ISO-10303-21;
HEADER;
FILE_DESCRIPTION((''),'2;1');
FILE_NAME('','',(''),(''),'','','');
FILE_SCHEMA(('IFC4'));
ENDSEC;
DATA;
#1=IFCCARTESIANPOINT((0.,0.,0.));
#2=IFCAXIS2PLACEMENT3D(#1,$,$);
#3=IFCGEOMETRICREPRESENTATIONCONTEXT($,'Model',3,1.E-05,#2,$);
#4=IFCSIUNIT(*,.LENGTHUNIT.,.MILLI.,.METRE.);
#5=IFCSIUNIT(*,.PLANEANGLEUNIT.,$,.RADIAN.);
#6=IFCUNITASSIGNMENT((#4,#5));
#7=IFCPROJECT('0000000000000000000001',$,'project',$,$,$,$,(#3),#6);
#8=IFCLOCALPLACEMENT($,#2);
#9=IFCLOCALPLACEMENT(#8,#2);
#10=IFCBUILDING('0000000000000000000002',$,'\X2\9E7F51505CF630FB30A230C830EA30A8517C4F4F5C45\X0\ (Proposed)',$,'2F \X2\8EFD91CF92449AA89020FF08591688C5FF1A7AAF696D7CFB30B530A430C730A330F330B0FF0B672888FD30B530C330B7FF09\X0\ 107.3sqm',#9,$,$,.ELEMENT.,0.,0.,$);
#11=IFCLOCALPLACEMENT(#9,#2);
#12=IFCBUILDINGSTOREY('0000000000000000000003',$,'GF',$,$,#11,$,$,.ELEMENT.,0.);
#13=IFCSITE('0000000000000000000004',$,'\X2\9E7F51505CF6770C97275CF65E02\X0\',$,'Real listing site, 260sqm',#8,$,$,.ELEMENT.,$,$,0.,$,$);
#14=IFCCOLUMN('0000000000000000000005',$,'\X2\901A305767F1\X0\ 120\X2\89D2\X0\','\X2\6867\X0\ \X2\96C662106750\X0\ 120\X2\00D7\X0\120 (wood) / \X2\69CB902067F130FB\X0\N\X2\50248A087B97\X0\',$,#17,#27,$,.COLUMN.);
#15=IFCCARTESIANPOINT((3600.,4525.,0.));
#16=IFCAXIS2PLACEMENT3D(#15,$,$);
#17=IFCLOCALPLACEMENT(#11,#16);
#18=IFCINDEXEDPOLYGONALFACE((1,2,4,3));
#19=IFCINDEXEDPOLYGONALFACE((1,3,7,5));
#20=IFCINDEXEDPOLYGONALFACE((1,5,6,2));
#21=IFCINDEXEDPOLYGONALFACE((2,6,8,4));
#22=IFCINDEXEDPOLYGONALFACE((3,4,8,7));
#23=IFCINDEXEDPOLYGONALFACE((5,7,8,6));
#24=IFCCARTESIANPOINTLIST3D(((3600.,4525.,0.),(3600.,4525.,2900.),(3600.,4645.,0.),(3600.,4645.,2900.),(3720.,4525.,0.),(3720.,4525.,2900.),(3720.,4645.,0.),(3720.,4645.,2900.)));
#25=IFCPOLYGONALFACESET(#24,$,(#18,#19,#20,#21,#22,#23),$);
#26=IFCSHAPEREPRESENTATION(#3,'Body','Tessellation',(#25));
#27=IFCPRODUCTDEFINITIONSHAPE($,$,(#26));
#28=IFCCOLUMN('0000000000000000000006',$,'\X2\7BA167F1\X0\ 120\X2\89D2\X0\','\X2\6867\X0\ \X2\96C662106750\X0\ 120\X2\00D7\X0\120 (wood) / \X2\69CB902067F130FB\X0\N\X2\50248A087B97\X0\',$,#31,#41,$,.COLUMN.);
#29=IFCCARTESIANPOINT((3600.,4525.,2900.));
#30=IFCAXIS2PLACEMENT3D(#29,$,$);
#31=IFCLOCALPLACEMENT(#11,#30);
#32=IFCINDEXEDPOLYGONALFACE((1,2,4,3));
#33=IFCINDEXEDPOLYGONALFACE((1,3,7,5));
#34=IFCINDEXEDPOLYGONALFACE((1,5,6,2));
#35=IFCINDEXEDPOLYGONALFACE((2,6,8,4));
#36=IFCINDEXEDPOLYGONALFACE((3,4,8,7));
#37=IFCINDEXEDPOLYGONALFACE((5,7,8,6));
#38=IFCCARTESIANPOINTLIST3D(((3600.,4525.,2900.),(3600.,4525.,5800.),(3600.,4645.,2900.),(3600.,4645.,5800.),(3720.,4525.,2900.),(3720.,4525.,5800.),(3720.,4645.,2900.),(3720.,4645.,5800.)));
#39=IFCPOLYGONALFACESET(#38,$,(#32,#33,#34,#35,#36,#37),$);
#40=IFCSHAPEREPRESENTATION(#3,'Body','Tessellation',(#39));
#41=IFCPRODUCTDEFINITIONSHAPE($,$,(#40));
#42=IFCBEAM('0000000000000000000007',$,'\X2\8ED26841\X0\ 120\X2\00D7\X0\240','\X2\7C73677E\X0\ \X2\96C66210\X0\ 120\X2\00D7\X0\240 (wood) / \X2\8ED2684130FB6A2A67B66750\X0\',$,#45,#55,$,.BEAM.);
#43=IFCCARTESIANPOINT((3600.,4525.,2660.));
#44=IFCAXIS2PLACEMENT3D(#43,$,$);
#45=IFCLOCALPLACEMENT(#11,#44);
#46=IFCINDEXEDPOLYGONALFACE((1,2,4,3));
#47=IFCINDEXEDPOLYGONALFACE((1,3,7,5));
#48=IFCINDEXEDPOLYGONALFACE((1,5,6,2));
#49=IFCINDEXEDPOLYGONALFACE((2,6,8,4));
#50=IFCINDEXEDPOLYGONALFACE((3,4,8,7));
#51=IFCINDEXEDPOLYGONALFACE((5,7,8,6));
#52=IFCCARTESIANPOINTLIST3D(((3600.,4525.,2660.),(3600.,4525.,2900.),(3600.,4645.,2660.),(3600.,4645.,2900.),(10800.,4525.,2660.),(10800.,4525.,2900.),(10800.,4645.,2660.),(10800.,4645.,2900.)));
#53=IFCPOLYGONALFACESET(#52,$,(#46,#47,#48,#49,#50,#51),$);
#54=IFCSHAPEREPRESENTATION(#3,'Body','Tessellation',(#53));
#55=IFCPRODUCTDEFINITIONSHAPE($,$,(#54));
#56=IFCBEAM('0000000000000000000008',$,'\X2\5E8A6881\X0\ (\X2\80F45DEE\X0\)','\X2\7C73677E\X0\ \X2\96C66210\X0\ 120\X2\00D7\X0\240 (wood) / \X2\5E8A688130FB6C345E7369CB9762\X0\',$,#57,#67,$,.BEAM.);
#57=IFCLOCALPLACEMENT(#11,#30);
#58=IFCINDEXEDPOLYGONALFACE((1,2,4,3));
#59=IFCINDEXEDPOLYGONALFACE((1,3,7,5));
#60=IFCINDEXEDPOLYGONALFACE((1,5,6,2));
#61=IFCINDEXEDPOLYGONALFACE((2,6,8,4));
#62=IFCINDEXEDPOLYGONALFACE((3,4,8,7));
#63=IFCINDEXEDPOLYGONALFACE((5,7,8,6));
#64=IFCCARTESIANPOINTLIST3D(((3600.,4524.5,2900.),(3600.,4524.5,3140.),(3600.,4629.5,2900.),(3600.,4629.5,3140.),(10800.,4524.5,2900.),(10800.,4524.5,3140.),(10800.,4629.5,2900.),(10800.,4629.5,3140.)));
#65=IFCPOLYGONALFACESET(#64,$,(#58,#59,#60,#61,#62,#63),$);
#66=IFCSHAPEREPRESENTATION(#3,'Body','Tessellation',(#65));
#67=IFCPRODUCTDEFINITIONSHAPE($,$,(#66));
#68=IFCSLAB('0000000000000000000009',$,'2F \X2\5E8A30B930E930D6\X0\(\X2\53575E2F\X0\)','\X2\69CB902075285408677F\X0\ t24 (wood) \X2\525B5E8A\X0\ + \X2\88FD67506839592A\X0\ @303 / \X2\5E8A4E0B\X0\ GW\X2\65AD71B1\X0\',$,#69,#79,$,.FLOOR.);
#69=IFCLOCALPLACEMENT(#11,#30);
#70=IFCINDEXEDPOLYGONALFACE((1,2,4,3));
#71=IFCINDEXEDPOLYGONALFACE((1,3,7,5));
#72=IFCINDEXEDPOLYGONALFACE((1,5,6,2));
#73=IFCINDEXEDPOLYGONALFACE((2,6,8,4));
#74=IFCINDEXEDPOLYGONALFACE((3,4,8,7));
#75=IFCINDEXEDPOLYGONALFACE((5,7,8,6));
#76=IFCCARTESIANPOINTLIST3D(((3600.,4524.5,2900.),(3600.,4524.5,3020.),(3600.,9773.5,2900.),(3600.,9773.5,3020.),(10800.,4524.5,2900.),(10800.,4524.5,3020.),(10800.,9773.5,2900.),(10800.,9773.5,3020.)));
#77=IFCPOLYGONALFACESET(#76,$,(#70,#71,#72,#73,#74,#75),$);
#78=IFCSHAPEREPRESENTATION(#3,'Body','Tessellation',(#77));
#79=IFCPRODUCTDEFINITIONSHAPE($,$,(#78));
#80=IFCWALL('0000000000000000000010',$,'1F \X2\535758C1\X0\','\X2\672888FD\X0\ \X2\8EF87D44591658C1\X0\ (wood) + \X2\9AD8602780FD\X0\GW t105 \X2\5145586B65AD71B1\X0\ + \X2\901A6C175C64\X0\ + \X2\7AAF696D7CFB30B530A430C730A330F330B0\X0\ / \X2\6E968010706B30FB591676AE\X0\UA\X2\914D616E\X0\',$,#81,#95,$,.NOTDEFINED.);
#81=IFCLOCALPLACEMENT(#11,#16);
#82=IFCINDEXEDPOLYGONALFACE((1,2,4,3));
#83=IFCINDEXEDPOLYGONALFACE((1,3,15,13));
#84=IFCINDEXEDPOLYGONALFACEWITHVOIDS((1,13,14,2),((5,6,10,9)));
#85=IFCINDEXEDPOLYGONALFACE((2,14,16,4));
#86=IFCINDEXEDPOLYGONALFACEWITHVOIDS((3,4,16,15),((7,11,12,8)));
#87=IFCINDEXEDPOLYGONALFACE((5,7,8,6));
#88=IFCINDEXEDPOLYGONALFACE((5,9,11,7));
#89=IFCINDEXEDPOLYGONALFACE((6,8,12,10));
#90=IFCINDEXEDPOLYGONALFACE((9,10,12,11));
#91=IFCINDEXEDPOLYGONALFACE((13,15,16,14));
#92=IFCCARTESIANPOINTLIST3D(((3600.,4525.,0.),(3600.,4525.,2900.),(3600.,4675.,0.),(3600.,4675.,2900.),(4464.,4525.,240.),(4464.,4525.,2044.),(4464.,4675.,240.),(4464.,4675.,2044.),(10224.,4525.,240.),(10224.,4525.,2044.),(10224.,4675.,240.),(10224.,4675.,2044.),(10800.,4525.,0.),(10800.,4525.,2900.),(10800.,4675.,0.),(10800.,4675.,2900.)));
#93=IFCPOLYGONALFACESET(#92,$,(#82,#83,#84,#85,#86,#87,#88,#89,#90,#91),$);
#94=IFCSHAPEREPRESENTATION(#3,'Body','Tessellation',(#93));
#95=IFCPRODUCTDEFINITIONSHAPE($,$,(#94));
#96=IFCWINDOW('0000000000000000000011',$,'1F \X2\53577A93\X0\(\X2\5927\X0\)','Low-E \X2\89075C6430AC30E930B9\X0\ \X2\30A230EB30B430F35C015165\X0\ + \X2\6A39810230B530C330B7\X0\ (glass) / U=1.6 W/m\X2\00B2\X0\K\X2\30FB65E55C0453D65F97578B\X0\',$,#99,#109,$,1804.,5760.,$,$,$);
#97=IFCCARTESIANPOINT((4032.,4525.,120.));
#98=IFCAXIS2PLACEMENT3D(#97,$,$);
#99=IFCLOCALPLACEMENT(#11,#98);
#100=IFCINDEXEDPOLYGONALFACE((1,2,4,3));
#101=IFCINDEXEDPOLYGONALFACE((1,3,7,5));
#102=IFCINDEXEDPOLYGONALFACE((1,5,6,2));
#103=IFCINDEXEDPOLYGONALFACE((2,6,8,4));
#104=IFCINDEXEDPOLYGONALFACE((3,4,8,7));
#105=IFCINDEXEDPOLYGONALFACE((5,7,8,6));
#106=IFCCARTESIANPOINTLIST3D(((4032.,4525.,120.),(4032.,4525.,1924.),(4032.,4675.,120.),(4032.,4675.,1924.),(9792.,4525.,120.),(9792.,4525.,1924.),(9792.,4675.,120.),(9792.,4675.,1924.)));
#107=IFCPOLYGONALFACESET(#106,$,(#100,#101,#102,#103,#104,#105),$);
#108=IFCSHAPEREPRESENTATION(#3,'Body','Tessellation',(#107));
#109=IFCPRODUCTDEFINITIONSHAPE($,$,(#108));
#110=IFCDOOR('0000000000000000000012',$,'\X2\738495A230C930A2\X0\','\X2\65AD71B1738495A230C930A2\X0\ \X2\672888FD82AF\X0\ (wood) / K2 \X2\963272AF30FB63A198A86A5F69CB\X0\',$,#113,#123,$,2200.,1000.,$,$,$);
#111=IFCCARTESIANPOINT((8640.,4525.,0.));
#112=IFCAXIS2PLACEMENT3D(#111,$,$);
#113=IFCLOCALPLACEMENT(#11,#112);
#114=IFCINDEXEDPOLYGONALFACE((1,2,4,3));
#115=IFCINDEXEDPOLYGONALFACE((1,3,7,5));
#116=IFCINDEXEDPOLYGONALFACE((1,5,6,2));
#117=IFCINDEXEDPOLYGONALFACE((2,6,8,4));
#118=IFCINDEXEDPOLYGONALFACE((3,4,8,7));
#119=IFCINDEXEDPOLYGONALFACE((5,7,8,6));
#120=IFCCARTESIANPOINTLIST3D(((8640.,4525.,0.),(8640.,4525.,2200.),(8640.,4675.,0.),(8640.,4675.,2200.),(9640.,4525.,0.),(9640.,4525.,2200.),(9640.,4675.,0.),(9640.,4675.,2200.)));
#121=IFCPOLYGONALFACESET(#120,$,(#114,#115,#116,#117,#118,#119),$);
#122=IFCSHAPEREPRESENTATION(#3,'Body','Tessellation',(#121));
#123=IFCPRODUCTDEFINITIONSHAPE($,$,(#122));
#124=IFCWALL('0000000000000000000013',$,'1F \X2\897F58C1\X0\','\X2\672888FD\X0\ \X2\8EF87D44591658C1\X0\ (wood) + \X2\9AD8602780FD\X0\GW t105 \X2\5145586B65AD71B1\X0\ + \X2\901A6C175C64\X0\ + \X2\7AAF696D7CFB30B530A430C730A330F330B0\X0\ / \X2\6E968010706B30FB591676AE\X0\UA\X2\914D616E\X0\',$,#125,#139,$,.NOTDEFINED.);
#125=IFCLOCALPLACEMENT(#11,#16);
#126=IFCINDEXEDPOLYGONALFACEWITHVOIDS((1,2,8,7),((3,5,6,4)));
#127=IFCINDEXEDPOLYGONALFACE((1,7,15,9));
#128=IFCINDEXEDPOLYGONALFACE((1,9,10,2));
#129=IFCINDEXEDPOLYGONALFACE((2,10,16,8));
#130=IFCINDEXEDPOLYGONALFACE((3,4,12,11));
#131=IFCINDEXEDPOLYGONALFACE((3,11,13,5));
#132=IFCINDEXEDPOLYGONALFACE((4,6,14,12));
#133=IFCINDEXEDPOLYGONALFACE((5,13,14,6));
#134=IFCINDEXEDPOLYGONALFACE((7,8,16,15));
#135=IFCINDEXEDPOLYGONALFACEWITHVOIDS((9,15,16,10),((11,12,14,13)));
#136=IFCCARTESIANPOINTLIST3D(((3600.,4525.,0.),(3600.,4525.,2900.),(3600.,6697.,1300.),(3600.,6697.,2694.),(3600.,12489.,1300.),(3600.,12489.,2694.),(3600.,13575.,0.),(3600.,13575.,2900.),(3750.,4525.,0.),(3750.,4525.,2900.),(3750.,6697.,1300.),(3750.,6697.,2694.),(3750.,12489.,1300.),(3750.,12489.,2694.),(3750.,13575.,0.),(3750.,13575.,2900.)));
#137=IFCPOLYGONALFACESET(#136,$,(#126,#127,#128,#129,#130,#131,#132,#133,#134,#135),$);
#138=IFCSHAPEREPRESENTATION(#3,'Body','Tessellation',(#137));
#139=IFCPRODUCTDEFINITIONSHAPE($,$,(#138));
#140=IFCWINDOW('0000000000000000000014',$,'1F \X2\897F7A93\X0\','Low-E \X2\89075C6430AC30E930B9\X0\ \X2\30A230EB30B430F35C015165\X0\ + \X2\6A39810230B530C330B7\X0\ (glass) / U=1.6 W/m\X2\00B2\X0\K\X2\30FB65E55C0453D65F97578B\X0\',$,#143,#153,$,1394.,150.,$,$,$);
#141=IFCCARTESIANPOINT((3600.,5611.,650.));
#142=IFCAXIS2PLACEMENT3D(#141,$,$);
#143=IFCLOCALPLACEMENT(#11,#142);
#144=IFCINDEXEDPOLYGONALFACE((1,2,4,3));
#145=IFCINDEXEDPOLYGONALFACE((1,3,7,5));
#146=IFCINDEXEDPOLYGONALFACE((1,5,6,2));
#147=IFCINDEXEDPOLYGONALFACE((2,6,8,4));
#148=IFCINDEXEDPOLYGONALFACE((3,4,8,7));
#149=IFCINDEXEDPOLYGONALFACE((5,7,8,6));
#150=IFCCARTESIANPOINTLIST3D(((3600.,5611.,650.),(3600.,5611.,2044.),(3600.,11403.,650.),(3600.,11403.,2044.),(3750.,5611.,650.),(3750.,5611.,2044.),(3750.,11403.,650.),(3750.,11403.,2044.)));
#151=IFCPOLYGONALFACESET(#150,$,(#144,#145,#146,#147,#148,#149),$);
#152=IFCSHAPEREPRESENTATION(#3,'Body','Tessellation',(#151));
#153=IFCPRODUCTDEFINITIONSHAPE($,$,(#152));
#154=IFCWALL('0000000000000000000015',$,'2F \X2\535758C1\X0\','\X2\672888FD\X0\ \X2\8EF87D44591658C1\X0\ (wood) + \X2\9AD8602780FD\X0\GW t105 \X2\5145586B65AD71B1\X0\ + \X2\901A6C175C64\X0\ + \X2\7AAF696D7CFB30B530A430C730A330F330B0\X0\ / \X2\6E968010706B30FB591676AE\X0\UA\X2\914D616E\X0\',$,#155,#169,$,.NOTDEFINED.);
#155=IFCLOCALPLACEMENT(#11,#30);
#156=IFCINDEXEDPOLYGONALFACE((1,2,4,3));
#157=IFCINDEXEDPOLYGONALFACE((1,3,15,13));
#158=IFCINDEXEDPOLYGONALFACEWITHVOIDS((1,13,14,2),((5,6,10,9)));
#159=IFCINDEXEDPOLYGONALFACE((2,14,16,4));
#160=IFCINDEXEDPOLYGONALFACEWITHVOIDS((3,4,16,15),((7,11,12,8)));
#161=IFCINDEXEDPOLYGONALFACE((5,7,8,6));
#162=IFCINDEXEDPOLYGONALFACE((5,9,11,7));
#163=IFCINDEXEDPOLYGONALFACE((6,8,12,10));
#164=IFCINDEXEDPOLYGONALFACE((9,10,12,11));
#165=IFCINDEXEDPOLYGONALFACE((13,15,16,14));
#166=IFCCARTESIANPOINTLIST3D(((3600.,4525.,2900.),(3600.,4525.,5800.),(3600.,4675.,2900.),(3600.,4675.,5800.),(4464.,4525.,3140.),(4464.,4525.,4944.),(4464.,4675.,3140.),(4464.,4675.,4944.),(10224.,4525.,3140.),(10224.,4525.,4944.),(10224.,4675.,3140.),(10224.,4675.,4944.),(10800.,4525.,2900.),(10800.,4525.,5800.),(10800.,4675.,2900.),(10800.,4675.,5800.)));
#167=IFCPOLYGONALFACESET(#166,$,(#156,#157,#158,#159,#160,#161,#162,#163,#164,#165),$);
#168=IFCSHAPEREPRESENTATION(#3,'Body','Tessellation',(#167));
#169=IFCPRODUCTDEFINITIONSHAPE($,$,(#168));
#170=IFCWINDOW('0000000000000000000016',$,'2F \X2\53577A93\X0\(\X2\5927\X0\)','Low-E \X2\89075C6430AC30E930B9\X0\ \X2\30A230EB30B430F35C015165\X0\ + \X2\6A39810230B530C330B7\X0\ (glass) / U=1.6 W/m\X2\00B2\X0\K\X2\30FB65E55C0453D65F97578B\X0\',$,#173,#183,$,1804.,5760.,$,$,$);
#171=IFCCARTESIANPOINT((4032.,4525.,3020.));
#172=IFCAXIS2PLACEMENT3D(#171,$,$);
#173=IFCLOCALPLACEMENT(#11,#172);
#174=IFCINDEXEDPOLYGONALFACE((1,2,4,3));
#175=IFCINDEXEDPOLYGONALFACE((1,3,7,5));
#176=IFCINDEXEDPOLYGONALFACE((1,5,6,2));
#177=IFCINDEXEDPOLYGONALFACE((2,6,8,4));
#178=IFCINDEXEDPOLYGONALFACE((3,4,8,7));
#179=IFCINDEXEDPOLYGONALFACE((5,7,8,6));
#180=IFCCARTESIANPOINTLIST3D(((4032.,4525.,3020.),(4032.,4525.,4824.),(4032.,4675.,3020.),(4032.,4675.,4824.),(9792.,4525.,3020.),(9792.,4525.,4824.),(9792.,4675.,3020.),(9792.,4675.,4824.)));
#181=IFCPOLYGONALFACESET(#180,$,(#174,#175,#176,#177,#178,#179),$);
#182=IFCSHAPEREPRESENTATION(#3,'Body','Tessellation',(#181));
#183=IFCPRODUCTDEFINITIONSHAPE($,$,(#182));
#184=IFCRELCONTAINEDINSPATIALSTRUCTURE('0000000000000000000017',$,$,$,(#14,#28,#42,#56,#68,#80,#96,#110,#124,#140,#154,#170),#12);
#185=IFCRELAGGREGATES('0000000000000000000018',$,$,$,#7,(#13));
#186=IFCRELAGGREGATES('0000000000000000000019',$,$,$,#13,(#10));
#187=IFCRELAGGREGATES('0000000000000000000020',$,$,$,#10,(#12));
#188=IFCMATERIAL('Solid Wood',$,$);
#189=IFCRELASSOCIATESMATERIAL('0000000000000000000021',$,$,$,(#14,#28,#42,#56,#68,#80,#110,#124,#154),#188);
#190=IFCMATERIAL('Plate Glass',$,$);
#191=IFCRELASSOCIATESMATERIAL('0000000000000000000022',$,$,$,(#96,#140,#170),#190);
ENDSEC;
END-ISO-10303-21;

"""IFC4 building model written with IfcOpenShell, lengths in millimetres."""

from ifc_helpers import new_model, si_unit, frame, frame_2d, origin, place, context, project, spatial, rectangle, extrude, material, element, fill, save


model = new_model("IFC4")

# Units and contexts
model_context = context("Model", 3, precision=1e-05, world=origin())
ifc_project = project(units=[si_unit("LENGTHUNIT", "METRE", prefix="MILLI"), si_unit("PLANEANGLEUNIT", "RADIAN")], contexts=[model_context])

# Site, building, storey
site_placement = place(None, origin())
site = spatial("IfcSite", under=ifc_project, at=site_placement, Name="鹿児島県霧島市", ObjectType="Real listing site, 260sqm", CompositionType="ELEMENT", RefElevation=0.0)
building_placement = place(site_placement, origin())
building = spatial("IfcBuilding", under=site, at=building_placement, Name="鹿児島・アトリエ兼住居 (Proposed)", ObjectType="2F 軽量鉄骨造（外装：窯業系サイディング＋木製サッシ） 107.3sqm", CompositionType="ELEMENT", ElevationOfRefHeight=0.0, ElevationOfTerrain=0.0)
storey_placement = place(building_placement, origin())
storey = spatial("IfcBuildingStorey", under=building, at=storey_placement, Name="GF", CompositionType="ELEMENT", Elevation=0.0)

# Columns
ifc_material_1 = material(Name="Solid Wood")
column_1_placement = place(storey_placement, frame((3600.0, 4525.0, 0.0)))
element("IfcColumn", 1, at=column_1_placement, inside=storey, material=ifc_material_1, Name="通し柱 120角", Description="桧 集成材 120×120 (wood) / 構造柱・N値計算", PredefinedType="COLUMN", context=model_context, shape_type="SweptSolid", body=[
    extrude(rectangle(XDim=120.0, YDim=120.0, at=frame_2d((60.0, 60.0))), frame((3600.0, 4525.0, 0.0)), (0.0, 0.0, 1.0), 2900.0),
])
column_2_placement = place(storey_placement, frame((3600.0, 4525.0, 2900.0)))
element("IfcColumn", 2, at=column_2_placement, inside=storey, material=ifc_material_1, Name="管柱 120角", Description="桧 集成材 120×120 (wood) / 構造柱・N値計算", PredefinedType="COLUMN", context=model_context, shape_type="SweptSolid", body=[
    extrude(rectangle(XDim=120.0, YDim=120.0, at=frame_2d((60.0, 60.0))), frame((3600.0, 4525.0, 2900.0)), (0.0, 0.0, 1.0), 2900.0),
])

# Beams
beam_1_placement = place(storey_placement, frame((3600.0, 4525.0, 2660.0)))
element("IfcBeam", 3, at=beam_1_placement, inside=storey, material=ifc_material_1, Name="軒桁 120×240", Description="米松 集成 120×240 (wood) / 軒桁・横架材", PredefinedType="BEAM", context=model_context, shape_type="SweptSolid", body=[
    extrude(rectangle(XDim=7200.0, YDim=120.0, at=frame_2d((3600.0, 60.0))), frame((3600.0, 4525.0, 2660.0)), (0.0, 0.0, 1.0), 240.0),
])
beam_2_placement = place(storey_placement, frame((3600.0, 4525.0, 2900.0)))
element("IfcBeam", 4, at=beam_2_placement, inside=storey, material=ifc_material_1, Name="床梁 (胴差)", Description="米松 集成 120×240 (wood) / 床梁・水平構面", PredefinedType="BEAM", context=model_context, shape_type="SweptSolid", body=[
    extrude(rectangle(XDim=7200.0, YDim=105.0, at=frame_2d((3600.0, 52.0))), frame((3600.0, 4525.0, 2900.0)), (0.0, 0.0, 1.0), 240.0),
])

# Slab
slab_1_placement = place(storey_placement, frame((3600.0, 4525.0, 2900.0)))
element("IfcSlab", 5, at=slab_1_placement, inside=storey, material=ifc_material_1, Name="2F 床スラブ(南帯)", Description="構造用合板 t24 (wood) 剛床 + 製材根太 @303 / 床下 GW断熱", PredefinedType="FLOOR", context=model_context, shape_type="SweptSolid", body=[
    extrude(rectangle(XDim=7200.0, YDim=5249.0, at=frame_2d((3600.0, 2624.0))), frame((3600.0, 4525.0, 2900.0)), (0.0, 0.0, 1.0), 120.0),
])

# Wall, openings, window, door
wall_1_placement = place(storey_placement, frame((3600.0, 4525.0, 0.0)))
wall_1 = element("IfcWall", 6, at=wall_1_placement, inside=storey, material=ifc_material_1, Name="1F 南壁", Description="木製 軸組外壁 (wood) + 高性能GW t105 充填断熱 + 通気層 + 窯業系サイディング / 準耐火・外皮UA配慮", PredefinedType="NOTDEFINED", context=model_context, shape_type="SweptSolid", body=[
    extrude(rectangle(XDim=7200.0, YDim=150.0, at=frame_2d((3600.0, 75.0))), frame((3600.0, 4525.0, 0.0)), (0.0, 0.0, 1.0), 2900.0),
])
opening_1_placement = place(storey_placement, frame((4032.0, 4525.0, 120.0)))
opening_1 = element("IfcOpeningElement", 7, at=opening_1_placement, cuts=wall_1, PredefinedType="NOTDEFINED", context=model_context, shape_type="SweptSolid", body=[
    extrude(rectangle(XDim=5760.0, YDim=150.0, at=frame_2d((2880.0, 75.0))), frame((4032.0, 4525.0, 120.0)), (0.0, 0.0, 1.0), 1804.0),
])
opening_2_placement = place(storey_placement, frame((8640.0, 4525.0, 0.0)))
opening_2 = element("IfcOpeningElement", 8, at=opening_2_placement, cuts=wall_1, PredefinedType="NOTDEFINED", context=model_context, shape_type="SweptSolid", body=[
    extrude(rectangle(XDim=1000.0, YDim=150.0, at=frame_2d((500.0, 75.0))), frame((8640.0, 4525.0, 0.0)), (0.0, 0.0, 1.0), 2200.0),
])
ifc_material_2 = material(Name="Plate Glass")
window_1_placement = place(storey_placement, frame((4032.0, 4525.0, 120.0)))
window_1 = element("IfcWindow", 9, at=window_1_placement, inside=storey, material=ifc_material_2, Name="1F 南窓(大)", Description="Low-E 複層ガラス アルゴン封入 + 樹脂サッシ (glass) / U=1.6 W/m²K・日射取得型", OverallHeight=1804.0, OverallWidth=5760.0, context=model_context, shape_type="SweptSolid", body=[
    extrude(rectangle(XDim=5760.0, YDim=150.0, at=frame_2d((2880.0, 75.0))), frame((4032.0, 4525.0, 120.0)), (0.0, 0.0, 1.0), 1804.0),
])
fill(opening_1, window_1)
door_placement = place(storey_placement, frame((8640.0, 4525.0, 0.0)))
door = element("IfcDoor", 10, at=door_placement, inside=storey, material=ifc_material_1, Name="玄関ドア", Description="断熱玄関ドア 木製芯 (wood) / K2 防犯・採風機構", OverallHeight=2200.0, OverallWidth=1000.0, context=model_context, shape_type="SweptSolid", body=[
    extrude(rectangle(XDim=1000.0, YDim=150.0, at=frame_2d((500.0, 75.0))), frame((8640.0, 4525.0, 0.0)), (0.0, 0.0, 1.0), 2200.0),
])
fill(opening_2, door)

# Walls, openings, windows
wall_2_placement = place(storey_placement, frame((3600.0, 4525.0, 0.0)))
wall_2 = element("IfcWall", 11, at=wall_2_placement, inside=storey, material=ifc_material_1, Name="1F 西壁", Description="木製 軸組外壁 (wood) + 高性能GW t105 充填断熱 + 通気層 + 窯業系サイディング / 準耐火・外皮UA配慮", PredefinedType="NOTDEFINED", context=model_context, shape_type="SweptSolid", body=[
    extrude(rectangle(XDim=150.0, YDim=9050.0, at=frame_2d((75.0, 4525.0))), frame((3600.0, 4525.0, 0.0)), (0.0, 0.0, 1.0), 2900.0),
])
opening_3_placement = place(storey_placement, frame((3600.0, 5611.0, 650.0)))
opening_3 = element("IfcOpeningElement", 12, at=opening_3_placement, cuts=wall_2, PredefinedType="NOTDEFINED", context=model_context, shape_type="SweptSolid", body=[
    extrude(rectangle(XDim=150.0, YDim=5792.0, at=frame_2d((75.0, 2896.0))), frame((3600.0, 5611.0, 650.0)), (0.0, 0.0, 1.0), 1394.0),
])
window_2_placement = place(storey_placement, frame((3600.0, 5611.0, 650.0)))
window_2 = element("IfcWindow", 13, at=window_2_placement, inside=storey, material=ifc_material_2, Name="1F 西窓", Description="Low-E 複層ガラス アルゴン封入 + 樹脂サッシ (glass) / U=1.6 W/m²K・日射取得型", OverallHeight=1394.0, OverallWidth=150.0, context=model_context, shape_type="SweptSolid", body=[
    extrude(rectangle(XDim=150.0, YDim=5792.0, at=frame_2d((75.0, 2896.0))), frame((3600.0, 5611.0, 650.0)), (0.0, 0.0, 1.0), 1394.0),
])
fill(opening_3, window_2)
wall_3_placement = place(storey_placement, frame((3600.0, 4525.0, 2900.0)))
wall_3 = element("IfcWall", 14, at=wall_3_placement, inside=storey, material=ifc_material_1, Name="2F 南壁", Description="木製 軸組外壁 (wood) + 高性能GW t105 充填断熱 + 通気層 + 窯業系サイディング / 準耐火・外皮UA配慮", PredefinedType="NOTDEFINED", context=model_context, shape_type="SweptSolid", body=[
    extrude(rectangle(XDim=7200.0, YDim=150.0, at=frame_2d((3600.0, 75.0))), frame((3600.0, 4525.0, 2900.0)), (0.0, 0.0, 1.0), 2900.0),
])
opening_4_placement = place(storey_placement, frame((4032.0, 4525.0, 3020.0)))
opening_4 = element("IfcOpeningElement", 15, at=opening_4_placement, cuts=wall_3, PredefinedType="NOTDEFINED", context=model_context, shape_type="SweptSolid", body=[
    extrude(rectangle(XDim=5760.0, YDim=150.0, at=frame_2d((2880.0, 75.0))), frame((4032.0, 4525.0, 3020.0)), (0.0, 0.0, 1.0), 1804.0),
])
window_3_placement = place(storey_placement, frame((4032.0, 4525.0, 3020.0)))
window_3 = element("IfcWindow", 16, at=window_3_placement, inside=storey, material=ifc_material_2, Name="2F 南窓(大)", Description="Low-E 複層ガラス アルゴン封入 + 樹脂サッシ (glass) / U=1.6 W/m²K・日射取得型", OverallHeight=1804.0, OverallWidth=5760.0, context=model_context, shape_type="SweptSolid", body=[
    extrude(rectangle(XDim=5760.0, YDim=150.0, at=frame_2d((2880.0, 75.0))), frame((4032.0, 4525.0, 3020.0)), (0.0, 0.0, 1.0), 1804.0),
])
fill(opening_4, window_3)

save(model, "model.ifc")
